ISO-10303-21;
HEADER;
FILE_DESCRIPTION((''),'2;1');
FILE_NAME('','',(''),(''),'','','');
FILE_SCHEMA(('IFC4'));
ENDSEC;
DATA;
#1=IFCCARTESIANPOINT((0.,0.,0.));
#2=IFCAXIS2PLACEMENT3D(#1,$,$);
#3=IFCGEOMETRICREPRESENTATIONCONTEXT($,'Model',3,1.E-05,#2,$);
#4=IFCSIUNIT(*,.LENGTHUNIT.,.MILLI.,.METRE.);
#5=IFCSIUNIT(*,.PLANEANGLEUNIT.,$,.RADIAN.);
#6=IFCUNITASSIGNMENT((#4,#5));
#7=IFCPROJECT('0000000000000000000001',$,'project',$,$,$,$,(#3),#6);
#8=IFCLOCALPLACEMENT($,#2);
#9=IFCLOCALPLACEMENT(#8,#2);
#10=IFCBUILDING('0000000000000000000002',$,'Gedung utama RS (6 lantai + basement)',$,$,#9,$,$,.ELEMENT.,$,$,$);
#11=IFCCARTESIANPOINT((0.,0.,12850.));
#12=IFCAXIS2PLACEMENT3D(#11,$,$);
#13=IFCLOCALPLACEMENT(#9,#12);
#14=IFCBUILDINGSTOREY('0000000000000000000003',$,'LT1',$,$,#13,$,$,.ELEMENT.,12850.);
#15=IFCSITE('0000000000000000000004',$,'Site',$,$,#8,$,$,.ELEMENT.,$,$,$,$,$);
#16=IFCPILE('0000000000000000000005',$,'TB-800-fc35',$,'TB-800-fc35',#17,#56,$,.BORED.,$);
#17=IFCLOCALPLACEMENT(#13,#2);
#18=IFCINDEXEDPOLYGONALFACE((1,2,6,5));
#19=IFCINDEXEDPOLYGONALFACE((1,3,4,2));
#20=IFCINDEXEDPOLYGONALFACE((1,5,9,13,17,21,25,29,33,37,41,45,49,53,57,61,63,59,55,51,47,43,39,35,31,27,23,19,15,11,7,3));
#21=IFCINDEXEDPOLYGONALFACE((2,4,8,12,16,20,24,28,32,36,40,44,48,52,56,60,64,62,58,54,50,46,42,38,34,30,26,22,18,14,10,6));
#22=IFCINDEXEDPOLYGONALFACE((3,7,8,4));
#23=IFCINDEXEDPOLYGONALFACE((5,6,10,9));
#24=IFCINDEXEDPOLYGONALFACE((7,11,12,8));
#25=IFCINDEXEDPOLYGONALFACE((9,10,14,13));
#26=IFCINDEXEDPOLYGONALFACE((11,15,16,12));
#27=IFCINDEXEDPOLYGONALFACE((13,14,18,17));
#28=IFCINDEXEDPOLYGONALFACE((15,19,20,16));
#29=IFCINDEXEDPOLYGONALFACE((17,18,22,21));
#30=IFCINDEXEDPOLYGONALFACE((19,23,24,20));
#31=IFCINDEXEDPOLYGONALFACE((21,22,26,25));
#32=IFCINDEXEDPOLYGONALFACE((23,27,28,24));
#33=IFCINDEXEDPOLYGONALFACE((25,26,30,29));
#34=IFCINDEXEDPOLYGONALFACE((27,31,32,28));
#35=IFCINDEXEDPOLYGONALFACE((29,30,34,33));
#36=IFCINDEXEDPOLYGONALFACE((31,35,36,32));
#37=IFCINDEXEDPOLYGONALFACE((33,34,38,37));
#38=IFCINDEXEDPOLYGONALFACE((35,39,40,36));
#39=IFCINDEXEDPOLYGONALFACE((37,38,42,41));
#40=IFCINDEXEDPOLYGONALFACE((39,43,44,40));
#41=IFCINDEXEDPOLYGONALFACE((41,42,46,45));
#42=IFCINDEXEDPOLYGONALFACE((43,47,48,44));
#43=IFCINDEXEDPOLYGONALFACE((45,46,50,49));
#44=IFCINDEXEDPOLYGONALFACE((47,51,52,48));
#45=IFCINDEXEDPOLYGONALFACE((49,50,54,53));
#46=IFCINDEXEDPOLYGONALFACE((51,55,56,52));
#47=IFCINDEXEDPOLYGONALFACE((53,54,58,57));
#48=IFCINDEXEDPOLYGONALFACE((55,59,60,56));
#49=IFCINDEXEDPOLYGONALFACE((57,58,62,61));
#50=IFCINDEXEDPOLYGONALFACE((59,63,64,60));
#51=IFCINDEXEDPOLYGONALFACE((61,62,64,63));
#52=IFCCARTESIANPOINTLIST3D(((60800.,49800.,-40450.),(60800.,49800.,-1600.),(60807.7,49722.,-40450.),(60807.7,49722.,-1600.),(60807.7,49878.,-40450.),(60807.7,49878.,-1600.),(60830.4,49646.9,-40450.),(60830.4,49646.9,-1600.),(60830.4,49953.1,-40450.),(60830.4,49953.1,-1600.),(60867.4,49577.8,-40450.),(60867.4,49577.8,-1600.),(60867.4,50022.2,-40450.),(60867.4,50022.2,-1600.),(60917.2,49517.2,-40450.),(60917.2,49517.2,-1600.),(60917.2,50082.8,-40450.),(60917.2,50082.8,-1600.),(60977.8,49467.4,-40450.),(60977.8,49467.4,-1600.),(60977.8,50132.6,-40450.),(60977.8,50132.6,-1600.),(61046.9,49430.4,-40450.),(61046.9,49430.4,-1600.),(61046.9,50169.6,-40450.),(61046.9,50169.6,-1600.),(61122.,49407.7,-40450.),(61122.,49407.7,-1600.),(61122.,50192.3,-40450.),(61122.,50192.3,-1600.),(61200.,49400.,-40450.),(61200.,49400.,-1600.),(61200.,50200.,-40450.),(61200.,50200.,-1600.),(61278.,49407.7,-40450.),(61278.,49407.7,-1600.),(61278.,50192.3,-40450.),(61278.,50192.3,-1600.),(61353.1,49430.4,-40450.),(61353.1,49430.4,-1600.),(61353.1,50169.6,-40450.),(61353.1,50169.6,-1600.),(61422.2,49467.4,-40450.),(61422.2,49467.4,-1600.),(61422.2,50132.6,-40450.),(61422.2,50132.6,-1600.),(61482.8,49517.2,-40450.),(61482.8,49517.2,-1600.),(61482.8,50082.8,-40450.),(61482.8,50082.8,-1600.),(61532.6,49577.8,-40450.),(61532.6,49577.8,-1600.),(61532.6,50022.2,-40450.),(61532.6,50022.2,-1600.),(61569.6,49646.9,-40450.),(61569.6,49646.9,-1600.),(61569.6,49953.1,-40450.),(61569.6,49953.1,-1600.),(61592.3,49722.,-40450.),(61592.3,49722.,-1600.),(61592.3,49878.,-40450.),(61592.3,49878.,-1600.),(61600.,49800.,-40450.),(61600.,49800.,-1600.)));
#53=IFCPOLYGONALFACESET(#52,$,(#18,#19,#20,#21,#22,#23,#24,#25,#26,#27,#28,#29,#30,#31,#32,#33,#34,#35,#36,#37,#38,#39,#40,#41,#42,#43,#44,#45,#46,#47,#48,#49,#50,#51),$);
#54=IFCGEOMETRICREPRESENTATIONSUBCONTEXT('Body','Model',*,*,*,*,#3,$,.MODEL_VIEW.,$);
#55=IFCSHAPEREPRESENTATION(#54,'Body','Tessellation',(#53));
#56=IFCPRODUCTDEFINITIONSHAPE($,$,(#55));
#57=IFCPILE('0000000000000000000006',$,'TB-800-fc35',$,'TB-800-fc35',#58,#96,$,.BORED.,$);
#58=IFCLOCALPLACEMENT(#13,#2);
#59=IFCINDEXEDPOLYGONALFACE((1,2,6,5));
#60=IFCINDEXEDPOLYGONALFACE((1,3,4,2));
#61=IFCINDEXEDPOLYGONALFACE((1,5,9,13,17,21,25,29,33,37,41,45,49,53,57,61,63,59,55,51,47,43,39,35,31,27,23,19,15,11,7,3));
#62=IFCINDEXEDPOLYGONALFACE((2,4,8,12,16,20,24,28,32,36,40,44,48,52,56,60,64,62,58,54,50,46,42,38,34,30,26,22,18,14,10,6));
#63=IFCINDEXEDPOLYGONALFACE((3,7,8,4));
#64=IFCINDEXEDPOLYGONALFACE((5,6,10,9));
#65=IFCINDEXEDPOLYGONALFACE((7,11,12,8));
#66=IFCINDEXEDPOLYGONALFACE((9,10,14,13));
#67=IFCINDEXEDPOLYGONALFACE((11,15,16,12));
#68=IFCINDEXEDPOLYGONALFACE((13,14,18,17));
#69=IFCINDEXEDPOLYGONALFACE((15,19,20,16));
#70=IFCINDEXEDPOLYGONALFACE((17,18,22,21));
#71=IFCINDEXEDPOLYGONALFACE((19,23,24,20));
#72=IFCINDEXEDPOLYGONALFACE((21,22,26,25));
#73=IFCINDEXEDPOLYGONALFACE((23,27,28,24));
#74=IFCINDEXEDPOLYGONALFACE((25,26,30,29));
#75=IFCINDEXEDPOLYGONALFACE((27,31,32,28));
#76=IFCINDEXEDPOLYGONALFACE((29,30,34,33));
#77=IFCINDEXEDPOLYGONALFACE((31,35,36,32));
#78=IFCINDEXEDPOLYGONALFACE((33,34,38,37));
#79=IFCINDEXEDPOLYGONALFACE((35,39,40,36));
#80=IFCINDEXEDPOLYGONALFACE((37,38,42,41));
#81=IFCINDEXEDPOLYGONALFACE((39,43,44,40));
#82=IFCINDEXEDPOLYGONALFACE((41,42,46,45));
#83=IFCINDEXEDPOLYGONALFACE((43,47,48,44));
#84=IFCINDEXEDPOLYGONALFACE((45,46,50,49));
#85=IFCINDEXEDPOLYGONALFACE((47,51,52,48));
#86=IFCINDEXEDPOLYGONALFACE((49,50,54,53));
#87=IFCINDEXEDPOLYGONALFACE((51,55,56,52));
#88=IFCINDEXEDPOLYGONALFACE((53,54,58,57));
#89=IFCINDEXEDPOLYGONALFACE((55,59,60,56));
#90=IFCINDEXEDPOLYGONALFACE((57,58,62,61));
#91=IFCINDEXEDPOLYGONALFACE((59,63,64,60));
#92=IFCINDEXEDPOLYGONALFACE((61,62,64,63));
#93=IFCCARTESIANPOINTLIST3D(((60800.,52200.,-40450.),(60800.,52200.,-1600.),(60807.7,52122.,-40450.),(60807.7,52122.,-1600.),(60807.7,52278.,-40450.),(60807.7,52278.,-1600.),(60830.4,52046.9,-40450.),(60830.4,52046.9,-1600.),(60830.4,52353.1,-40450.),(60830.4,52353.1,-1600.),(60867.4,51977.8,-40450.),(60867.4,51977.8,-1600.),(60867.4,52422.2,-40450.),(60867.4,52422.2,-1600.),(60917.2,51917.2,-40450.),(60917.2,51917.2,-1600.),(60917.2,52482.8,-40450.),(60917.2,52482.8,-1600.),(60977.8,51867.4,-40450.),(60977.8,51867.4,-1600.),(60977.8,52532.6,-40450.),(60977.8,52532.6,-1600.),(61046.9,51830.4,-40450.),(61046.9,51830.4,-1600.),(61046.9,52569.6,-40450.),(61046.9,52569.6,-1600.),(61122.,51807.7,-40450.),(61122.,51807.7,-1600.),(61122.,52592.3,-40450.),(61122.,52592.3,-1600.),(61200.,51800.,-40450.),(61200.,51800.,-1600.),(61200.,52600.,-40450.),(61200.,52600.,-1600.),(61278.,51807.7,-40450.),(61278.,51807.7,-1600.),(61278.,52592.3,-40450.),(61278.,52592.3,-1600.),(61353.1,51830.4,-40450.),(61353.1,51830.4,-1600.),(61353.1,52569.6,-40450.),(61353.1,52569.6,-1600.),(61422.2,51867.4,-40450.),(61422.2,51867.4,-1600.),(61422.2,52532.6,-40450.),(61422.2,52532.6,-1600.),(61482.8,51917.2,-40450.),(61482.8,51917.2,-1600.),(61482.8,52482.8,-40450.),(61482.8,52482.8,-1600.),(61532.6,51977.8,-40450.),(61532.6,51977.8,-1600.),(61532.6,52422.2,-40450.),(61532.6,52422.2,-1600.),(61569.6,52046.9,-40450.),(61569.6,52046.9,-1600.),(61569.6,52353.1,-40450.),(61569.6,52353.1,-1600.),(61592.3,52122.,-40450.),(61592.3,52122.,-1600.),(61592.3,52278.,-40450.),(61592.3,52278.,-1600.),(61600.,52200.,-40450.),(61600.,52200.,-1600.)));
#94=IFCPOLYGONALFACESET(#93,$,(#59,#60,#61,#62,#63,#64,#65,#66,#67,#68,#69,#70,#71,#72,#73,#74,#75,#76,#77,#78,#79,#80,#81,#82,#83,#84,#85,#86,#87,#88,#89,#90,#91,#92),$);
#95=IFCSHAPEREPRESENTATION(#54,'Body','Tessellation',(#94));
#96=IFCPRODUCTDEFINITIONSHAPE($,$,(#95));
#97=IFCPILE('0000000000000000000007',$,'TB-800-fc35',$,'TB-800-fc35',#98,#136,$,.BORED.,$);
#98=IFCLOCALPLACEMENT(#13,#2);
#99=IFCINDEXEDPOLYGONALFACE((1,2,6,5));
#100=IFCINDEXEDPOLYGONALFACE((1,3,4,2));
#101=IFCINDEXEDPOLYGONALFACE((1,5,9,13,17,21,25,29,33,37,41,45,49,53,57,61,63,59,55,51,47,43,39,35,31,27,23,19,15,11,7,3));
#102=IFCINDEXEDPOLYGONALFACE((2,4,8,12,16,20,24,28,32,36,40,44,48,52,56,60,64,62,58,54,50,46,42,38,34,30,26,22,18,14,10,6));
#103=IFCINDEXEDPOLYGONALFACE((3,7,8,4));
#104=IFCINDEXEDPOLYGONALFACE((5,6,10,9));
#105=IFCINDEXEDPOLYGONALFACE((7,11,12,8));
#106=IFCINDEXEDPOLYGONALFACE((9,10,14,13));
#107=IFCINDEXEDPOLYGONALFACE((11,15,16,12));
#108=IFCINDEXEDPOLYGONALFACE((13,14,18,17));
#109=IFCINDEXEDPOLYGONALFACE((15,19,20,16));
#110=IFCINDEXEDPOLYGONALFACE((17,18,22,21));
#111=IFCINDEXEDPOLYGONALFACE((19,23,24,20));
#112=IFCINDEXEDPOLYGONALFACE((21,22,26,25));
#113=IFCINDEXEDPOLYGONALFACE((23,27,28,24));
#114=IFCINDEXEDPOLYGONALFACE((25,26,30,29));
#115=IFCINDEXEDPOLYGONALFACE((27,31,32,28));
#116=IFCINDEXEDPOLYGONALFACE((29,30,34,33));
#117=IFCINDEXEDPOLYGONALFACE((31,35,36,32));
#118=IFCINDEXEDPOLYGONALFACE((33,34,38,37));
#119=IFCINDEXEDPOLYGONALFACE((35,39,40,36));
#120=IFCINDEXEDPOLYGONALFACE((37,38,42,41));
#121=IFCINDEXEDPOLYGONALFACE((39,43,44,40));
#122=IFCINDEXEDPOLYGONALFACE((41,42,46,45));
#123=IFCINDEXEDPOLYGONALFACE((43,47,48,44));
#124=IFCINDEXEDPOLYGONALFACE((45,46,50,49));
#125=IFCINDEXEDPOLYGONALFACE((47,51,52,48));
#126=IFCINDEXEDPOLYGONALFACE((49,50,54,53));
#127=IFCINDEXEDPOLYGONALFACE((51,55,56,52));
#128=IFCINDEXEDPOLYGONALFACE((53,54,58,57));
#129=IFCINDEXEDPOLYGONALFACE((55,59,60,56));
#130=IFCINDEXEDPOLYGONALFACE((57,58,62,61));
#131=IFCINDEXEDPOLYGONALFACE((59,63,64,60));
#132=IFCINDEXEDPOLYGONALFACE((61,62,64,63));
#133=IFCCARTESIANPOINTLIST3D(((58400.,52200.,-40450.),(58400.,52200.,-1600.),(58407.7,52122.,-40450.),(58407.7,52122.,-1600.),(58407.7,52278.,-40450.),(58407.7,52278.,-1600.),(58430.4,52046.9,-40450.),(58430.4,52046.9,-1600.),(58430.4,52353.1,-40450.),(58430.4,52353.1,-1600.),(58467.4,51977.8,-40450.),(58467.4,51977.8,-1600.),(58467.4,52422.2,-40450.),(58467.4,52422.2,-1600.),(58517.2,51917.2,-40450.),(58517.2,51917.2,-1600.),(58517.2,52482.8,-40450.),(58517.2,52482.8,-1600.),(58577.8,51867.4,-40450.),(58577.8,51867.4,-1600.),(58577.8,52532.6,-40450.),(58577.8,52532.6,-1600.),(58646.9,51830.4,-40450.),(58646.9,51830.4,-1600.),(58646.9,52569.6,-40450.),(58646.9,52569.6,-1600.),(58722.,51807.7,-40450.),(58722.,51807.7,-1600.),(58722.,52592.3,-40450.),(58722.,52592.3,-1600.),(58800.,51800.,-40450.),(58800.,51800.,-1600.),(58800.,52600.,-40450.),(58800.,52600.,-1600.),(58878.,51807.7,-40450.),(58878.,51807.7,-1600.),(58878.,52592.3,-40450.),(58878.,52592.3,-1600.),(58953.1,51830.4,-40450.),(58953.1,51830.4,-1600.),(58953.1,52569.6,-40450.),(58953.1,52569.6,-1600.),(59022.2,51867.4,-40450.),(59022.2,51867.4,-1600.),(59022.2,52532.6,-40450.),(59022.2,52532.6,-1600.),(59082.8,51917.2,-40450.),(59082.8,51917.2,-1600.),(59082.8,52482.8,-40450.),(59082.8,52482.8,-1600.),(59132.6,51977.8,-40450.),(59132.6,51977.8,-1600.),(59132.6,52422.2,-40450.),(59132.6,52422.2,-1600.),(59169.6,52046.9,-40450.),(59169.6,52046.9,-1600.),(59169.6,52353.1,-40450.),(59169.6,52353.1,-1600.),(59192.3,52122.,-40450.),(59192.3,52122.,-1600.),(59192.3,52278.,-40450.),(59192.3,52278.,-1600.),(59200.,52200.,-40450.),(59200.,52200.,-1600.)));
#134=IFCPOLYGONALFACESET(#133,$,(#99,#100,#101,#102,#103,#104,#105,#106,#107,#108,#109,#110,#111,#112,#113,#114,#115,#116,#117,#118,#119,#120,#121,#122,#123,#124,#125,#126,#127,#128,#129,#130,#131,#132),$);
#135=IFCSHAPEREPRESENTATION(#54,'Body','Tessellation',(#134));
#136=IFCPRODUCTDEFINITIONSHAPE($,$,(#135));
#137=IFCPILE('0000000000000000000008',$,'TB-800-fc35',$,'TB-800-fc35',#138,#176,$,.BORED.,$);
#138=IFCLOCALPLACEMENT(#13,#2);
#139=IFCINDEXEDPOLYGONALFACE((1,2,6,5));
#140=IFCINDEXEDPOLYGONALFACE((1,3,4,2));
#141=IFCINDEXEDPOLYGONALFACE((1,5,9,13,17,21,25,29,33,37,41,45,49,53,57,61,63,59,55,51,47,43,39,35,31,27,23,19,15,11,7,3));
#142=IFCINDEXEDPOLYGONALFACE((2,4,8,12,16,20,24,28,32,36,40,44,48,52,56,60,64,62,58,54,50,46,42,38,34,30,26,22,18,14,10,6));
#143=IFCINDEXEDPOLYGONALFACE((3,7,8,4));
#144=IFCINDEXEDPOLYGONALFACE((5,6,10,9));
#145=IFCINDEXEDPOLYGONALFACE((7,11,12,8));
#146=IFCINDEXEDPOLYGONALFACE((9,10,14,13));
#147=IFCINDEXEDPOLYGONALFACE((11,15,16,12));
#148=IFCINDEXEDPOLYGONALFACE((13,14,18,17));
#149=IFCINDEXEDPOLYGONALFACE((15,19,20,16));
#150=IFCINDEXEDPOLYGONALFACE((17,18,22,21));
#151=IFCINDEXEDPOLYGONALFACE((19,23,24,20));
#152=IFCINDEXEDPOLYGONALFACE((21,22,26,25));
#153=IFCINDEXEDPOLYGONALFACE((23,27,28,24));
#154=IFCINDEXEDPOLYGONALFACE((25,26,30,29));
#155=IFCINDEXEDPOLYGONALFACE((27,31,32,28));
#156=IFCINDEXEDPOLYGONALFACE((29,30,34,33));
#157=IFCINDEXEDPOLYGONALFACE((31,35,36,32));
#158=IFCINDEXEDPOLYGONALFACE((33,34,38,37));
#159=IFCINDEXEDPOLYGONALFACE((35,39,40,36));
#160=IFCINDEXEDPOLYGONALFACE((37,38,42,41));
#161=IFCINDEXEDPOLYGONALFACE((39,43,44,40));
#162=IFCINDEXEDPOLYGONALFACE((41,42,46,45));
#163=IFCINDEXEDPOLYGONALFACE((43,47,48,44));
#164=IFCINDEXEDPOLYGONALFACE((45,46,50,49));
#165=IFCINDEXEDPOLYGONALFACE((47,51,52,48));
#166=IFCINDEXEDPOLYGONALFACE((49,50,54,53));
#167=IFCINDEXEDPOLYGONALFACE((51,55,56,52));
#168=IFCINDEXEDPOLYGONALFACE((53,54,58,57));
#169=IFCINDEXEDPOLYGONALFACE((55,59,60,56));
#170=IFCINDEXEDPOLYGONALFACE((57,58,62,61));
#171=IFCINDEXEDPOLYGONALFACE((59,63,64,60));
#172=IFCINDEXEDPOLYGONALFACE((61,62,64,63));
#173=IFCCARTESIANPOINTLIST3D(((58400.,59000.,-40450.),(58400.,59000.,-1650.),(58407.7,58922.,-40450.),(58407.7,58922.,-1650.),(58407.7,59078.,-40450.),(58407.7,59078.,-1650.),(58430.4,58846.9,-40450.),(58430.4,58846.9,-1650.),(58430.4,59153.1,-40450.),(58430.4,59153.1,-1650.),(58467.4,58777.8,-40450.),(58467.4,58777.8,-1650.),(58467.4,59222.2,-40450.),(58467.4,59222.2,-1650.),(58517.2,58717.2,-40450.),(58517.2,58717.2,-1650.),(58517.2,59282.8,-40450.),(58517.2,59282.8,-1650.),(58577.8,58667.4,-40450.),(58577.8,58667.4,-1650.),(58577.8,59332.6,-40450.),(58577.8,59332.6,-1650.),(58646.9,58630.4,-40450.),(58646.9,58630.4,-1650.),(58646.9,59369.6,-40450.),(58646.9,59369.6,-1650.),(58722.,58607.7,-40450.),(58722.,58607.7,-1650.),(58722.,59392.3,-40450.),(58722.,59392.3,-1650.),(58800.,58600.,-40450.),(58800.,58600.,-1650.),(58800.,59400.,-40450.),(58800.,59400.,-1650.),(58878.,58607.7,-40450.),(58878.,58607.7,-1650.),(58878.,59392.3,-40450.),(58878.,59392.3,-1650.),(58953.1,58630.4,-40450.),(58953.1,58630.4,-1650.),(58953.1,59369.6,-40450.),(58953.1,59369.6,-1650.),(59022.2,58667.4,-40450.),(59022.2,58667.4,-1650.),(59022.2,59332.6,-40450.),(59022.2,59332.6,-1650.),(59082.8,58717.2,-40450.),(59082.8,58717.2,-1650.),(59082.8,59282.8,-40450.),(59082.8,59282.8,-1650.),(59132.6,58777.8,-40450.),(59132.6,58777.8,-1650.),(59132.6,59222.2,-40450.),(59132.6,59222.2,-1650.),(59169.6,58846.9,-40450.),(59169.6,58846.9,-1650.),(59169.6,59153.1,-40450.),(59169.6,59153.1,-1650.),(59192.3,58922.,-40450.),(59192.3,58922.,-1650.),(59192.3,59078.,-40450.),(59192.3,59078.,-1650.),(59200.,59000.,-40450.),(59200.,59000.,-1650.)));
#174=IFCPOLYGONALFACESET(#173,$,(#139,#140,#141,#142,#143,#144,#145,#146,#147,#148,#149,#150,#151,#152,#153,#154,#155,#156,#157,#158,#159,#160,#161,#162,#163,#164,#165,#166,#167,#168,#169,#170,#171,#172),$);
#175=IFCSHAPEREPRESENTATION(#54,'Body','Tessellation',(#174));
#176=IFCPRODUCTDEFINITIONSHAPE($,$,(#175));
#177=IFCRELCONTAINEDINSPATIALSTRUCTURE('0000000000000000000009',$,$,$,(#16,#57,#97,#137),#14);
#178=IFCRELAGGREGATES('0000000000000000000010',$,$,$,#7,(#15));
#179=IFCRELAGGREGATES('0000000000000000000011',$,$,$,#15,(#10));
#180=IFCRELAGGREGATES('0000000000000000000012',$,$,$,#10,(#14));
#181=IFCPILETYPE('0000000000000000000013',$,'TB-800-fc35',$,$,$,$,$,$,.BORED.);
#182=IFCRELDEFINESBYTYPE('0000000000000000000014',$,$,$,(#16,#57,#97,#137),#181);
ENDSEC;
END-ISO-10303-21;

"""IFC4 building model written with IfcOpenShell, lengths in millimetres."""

from ifc_helpers import new_model, si_unit, frame, origin, origin_2d, place, context, subcontext, project, spatial, circle, extrude, material_profile, profile_set, profile_usage, type_object, element, save


model = new_model("IFC4")

# Units and contexts
model_context = context("Model", 3, precision=1e-05, world=origin())
body_context = subcontext(model_context, "Body", "Model", "MODEL_VIEW")
ifc_project = project(units=[si_unit("LENGTHUNIT", "METRE", prefix="MILLI"), si_unit("PLANEANGLEUNIT", "RADIAN")], contexts=[model_context])

# Site, building, storey
site_placement = place(None, origin())
site = spatial("IfcSite", under=ifc_project, at=site_placement, Name="Site", CompositionType="ELEMENT")
building_placement = place(site_placement, origin())
building = spatial("IfcBuilding", under=site, at=building_placement, Name="Gedung utama RS (6 lantai + basement)", CompositionType="ELEMENT")
storey_placement = place(building_placement, frame((0.0, 0.0, 12850.0)))
storey = spatial("IfcBuildingStorey", under=building, at=storey_placement, Name="LT1", CompositionType="ELEMENT", Elevation=12850.0)

# Piles
ifc_material_profile = material_profile(None, circle(Radius=400.0, at=origin_2d()), Name="TB-800-fc35")
ifc_profile_set = profile_set([ifc_material_profile], Name="TB-800-fc35")
ifc_profile_usage = profile_usage(ifc_profile_set, cardinal=5)
pile_type = type_object("IfcPileType", Name="TB-800-fc35", PredefinedType="BORED", material=ifc_profile_set)
for number, where, z_axis, x_axis, name in (
    (1, (61200.0, 49800.0, -40450.0), (0.0, 0.0, 1.0), (1.0, 0.0, 0.0), "TB-800-fc35"),
    (2, (61200.0, 52200.0, -40450.0), (0.0, 0.0, 1.0), (1.0, 0.0, 0.0), "TB-800-fc35"),
    (3, (58800.0, 52200.0, -40450.0), (0.0, 0.0, 1.0), (1.0, 0.0, 0.0), "TB-800-fc35"),
):
    element("IfcPile", number, at=place(storey_placement, frame(where, z_axis=z_axis, x_axis=x_axis)), inside=storey, type_object=pile_type, material=ifc_profile_usage, Name=name, ObjectType="TB-800-fc35", PredefinedType="BORED", context=body_context, shape_type="SweptSolid", body=[
        extrude(circle(Radius=400.0, at=origin_2d()), origin(), (0.0, 0.0, 1.0), 38850.0),
    ])
for number, where, z_axis, x_axis, name in (
    (4, (58800.0, 59000.0, -40450.0), (0.0, 0.0, 1.0), (1.0, 0.0, 0.0), "TB-800-fc35"),
):
    element("IfcPile", number, at=place(storey_placement, frame(where, z_axis=z_axis, x_axis=x_axis)), inside=storey, type_object=pile_type, material=ifc_profile_usage, Name=name, ObjectType="TB-800-fc35", PredefinedType="BORED", context=body_context, shape_type="SweptSolid", body=[
        extrude(circle(Radius=400.0, at=origin_2d()), origin(), (0.0, 0.0, 1.0), 38800.0),
    ])

save(model, "model.ifc")
